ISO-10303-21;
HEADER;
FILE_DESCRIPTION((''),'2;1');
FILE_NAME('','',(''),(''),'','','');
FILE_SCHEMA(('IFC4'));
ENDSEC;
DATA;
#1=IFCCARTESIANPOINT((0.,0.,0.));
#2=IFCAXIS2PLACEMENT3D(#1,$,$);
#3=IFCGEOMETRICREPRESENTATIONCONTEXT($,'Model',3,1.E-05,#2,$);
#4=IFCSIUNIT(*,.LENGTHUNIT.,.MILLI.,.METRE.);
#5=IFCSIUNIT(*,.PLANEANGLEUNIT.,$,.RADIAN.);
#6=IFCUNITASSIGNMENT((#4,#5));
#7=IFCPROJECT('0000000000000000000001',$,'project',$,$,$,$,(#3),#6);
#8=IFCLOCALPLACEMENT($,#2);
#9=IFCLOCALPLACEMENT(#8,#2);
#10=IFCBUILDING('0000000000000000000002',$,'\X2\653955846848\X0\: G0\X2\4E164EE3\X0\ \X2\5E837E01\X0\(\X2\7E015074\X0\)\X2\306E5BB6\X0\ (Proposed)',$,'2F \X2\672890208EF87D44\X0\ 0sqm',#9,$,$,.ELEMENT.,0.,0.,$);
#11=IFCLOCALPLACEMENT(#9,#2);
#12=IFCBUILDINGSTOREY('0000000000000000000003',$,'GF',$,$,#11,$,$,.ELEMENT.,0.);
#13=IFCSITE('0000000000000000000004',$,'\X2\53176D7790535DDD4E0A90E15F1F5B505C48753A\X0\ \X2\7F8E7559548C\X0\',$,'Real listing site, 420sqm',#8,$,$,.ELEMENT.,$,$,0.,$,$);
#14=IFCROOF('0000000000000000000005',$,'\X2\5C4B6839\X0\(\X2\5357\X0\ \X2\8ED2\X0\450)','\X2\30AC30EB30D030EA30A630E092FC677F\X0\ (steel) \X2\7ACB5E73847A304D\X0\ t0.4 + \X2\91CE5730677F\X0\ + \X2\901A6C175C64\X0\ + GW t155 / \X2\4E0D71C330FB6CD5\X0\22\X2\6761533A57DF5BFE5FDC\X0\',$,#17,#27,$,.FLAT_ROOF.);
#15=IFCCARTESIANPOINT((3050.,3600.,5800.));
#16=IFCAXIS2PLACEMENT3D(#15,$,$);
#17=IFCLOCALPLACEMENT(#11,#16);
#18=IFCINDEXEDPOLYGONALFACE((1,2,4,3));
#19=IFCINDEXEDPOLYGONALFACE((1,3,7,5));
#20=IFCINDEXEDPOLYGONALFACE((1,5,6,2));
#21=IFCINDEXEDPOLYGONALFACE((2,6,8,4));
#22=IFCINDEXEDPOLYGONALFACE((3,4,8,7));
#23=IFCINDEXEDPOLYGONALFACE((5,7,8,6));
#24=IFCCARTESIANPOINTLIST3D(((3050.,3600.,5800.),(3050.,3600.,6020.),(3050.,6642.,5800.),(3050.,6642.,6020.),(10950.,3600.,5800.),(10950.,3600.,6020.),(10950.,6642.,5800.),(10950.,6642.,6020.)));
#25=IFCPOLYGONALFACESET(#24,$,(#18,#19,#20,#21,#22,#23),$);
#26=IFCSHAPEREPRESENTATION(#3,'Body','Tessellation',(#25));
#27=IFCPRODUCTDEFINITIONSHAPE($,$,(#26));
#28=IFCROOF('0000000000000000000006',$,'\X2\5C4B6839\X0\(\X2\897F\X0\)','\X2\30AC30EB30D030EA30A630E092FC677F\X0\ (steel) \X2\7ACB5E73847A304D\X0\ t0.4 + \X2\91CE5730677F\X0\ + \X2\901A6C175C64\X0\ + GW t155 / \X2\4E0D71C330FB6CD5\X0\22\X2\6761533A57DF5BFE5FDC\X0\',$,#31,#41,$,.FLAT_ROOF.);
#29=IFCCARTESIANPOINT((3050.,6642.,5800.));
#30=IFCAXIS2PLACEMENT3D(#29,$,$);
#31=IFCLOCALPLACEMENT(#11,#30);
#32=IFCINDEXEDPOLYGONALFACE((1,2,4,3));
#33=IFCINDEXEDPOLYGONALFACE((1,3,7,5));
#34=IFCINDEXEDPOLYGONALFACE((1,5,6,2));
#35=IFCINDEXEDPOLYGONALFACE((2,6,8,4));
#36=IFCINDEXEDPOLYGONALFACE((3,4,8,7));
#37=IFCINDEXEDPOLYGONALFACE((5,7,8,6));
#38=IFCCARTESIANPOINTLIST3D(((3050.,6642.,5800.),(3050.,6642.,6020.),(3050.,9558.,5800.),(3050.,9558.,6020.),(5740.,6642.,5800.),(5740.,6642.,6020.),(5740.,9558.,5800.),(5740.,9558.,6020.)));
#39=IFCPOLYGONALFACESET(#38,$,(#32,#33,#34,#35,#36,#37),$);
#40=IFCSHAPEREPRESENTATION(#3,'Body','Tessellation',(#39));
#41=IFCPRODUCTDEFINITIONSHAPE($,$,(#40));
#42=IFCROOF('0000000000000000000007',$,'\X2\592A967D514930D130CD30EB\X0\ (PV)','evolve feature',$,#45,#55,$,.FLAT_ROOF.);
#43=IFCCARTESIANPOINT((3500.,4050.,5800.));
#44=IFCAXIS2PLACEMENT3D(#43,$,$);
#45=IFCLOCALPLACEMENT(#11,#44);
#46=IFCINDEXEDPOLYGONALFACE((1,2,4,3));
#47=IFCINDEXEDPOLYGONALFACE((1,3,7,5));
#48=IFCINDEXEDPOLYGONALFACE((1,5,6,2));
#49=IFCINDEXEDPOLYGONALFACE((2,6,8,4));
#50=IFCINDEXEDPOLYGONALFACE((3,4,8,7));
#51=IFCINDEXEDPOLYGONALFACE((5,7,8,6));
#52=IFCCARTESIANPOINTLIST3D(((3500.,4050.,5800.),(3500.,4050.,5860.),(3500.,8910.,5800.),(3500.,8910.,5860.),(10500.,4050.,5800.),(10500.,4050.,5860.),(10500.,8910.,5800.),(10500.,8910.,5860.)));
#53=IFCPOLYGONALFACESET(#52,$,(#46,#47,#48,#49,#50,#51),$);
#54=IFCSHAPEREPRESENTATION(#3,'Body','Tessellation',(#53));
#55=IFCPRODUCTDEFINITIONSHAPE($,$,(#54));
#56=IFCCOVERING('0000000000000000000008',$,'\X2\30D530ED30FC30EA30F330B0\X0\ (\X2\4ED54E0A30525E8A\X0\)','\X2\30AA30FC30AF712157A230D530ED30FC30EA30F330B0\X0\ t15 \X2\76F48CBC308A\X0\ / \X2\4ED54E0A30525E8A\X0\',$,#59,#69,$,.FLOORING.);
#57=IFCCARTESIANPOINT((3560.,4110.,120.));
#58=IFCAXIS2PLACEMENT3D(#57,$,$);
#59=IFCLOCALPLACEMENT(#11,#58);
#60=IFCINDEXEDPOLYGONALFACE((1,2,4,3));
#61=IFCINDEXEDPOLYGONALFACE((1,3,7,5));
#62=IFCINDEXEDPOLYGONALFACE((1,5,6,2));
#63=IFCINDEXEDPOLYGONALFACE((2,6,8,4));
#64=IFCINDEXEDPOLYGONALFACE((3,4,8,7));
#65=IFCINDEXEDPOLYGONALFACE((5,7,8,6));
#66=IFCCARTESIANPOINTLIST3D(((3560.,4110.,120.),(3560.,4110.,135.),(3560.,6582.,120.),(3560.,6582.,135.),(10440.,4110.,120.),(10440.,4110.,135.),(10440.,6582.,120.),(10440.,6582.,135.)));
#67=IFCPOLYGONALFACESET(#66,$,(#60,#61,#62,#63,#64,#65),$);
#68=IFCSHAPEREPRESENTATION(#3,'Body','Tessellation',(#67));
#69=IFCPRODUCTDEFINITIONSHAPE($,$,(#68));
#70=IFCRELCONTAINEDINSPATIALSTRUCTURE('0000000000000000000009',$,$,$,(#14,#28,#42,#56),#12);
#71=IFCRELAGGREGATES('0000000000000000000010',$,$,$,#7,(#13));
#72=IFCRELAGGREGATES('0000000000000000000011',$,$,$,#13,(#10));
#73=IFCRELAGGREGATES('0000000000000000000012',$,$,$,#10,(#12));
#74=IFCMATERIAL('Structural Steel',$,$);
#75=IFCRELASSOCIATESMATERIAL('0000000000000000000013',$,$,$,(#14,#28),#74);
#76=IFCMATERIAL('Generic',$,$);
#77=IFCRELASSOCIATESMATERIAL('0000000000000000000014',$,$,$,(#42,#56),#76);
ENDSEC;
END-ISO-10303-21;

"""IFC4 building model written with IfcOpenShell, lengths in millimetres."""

from ifc_helpers import new_model, si_unit, frame, frame_2d, origin, place, context, project, spatial, rectangle, extrude, material, element, save


model = new_model("IFC4")

# Units and contexts
model_context = context("Model", 3, precision=1e-05, world=origin())
ifc_project = project(units=[si_unit("LENGTHUNIT", "METRE", prefix="MILLI"), si_unit("PLANEANGLEUNIT", "RADIAN")], contexts=[model_context])

# Site, building, storey
site_placement = place(None, origin())
site = spatial("IfcSite", under=ifc_project, at=site_placement, Name="北海道川上郡弟子屈町 美留和", ObjectType="Real listing site, 420sqm", CompositionType="ELEMENT", RefElevation=0.0)
building_placement = place(site_placement, origin())
building = spatial("IfcBuilding", under=site, at=building_placement, Name="改善案: G0世代 広縁(縁側)の家 (Proposed)", ObjectType="2F 木造軸組 0sqm", CompositionType="ELEMENT", ElevationOfRefHeight=0.0, ElevationOfTerrain=0.0)
storey_placement = place(building_placement, origin())
storey = spatial("IfcBuildingStorey", under=building, at=storey_placement, Name="GF", CompositionType="ELEMENT", Elevation=0.0)

# Shared definitions
ifc_material_1 = material(Name="Generic")

# Roofs
ifc_material_2 = material(Name="Structural Steel")
roof_1_placement = place(storey_placement, frame((3050.0, 3600.0, 5800.0)))
element("IfcRoof", 1, at=roof_1_placement, inside=storey, material=ifc_material_2, Name="屋根(南 軒450)", Description="ガルバリウム鋼板 (steel) 立平葺き t0.4 + 野地板 + 通気層 + GW t155 / 不燃・法22条区域対応", PredefinedType="FLAT_ROOF", context=model_context, shape_type="SweptSolid", body=[
    extrude(rectangle(XDim=7900.0, YDim=3042.0, at=frame_2d((3950.0, 1521.0))), frame((3050.0, 3600.0, 5800.0)), (0.0, 0.0, 1.0), 220.0),
])
roof_2_placement = place(storey_placement, frame((3050.0, 6642.0, 5800.0)))
element("IfcRoof", 2, at=roof_2_placement, inside=storey, material=ifc_material_2, Name="屋根(西)", Description="ガルバリウム鋼板 (steel) 立平葺き t0.4 + 野地板 + 通気層 + GW t155 / 不燃・法22条区域対応", PredefinedType="FLAT_ROOF", context=model_context, shape_type="SweptSolid", body=[
    extrude(rectangle(XDim=2690.0, YDim=2916.0, at=frame_2d((1345.0, 1458.0))), frame((3050.0, 6642.0, 5800.0)), (0.0, 0.0, 1.0), 220.0),
])
roof_3_placement = place(storey_placement, frame((3500.0, 4050.0, 5800.0)))
element("IfcRoof", 3, at=roof_3_placement, inside=storey, material=ifc_material_1, Name="太陽光パネル (PV)", Description="evolve feature", PredefinedType="FLAT_ROOF", context=model_context, shape_type="SweptSolid", body=[
    extrude(rectangle(XDim=7000.0, YDim=4860.0, at=frame_2d((3500.0, 2430.0))), frame((3500.0, 4050.0, 5800.0)), (0.0, 0.0, 1.0), 60.0),
])

# Covering
covering_placement = place(storey_placement, frame((3560.0, 4110.0, 120.0)))
element("IfcCovering", 4, at=covering_placement, inside=storey, material=ifc_material_1, Name="フローリング (仕上げ床)", Description="オーク無垢フローリング t15 直貼り / 仕上げ床", PredefinedType="FLOORING", context=model_context, shape_type="SweptSolid", body=[
    extrude(rectangle(XDim=6880.0, YDim=2472.0, at=frame_2d((3440.0, 1236.0))), frame((3560.0, 4110.0, 120.0)), (0.0, 0.0, 1.0), 15.0),
])

save(model, "model.ifc")
